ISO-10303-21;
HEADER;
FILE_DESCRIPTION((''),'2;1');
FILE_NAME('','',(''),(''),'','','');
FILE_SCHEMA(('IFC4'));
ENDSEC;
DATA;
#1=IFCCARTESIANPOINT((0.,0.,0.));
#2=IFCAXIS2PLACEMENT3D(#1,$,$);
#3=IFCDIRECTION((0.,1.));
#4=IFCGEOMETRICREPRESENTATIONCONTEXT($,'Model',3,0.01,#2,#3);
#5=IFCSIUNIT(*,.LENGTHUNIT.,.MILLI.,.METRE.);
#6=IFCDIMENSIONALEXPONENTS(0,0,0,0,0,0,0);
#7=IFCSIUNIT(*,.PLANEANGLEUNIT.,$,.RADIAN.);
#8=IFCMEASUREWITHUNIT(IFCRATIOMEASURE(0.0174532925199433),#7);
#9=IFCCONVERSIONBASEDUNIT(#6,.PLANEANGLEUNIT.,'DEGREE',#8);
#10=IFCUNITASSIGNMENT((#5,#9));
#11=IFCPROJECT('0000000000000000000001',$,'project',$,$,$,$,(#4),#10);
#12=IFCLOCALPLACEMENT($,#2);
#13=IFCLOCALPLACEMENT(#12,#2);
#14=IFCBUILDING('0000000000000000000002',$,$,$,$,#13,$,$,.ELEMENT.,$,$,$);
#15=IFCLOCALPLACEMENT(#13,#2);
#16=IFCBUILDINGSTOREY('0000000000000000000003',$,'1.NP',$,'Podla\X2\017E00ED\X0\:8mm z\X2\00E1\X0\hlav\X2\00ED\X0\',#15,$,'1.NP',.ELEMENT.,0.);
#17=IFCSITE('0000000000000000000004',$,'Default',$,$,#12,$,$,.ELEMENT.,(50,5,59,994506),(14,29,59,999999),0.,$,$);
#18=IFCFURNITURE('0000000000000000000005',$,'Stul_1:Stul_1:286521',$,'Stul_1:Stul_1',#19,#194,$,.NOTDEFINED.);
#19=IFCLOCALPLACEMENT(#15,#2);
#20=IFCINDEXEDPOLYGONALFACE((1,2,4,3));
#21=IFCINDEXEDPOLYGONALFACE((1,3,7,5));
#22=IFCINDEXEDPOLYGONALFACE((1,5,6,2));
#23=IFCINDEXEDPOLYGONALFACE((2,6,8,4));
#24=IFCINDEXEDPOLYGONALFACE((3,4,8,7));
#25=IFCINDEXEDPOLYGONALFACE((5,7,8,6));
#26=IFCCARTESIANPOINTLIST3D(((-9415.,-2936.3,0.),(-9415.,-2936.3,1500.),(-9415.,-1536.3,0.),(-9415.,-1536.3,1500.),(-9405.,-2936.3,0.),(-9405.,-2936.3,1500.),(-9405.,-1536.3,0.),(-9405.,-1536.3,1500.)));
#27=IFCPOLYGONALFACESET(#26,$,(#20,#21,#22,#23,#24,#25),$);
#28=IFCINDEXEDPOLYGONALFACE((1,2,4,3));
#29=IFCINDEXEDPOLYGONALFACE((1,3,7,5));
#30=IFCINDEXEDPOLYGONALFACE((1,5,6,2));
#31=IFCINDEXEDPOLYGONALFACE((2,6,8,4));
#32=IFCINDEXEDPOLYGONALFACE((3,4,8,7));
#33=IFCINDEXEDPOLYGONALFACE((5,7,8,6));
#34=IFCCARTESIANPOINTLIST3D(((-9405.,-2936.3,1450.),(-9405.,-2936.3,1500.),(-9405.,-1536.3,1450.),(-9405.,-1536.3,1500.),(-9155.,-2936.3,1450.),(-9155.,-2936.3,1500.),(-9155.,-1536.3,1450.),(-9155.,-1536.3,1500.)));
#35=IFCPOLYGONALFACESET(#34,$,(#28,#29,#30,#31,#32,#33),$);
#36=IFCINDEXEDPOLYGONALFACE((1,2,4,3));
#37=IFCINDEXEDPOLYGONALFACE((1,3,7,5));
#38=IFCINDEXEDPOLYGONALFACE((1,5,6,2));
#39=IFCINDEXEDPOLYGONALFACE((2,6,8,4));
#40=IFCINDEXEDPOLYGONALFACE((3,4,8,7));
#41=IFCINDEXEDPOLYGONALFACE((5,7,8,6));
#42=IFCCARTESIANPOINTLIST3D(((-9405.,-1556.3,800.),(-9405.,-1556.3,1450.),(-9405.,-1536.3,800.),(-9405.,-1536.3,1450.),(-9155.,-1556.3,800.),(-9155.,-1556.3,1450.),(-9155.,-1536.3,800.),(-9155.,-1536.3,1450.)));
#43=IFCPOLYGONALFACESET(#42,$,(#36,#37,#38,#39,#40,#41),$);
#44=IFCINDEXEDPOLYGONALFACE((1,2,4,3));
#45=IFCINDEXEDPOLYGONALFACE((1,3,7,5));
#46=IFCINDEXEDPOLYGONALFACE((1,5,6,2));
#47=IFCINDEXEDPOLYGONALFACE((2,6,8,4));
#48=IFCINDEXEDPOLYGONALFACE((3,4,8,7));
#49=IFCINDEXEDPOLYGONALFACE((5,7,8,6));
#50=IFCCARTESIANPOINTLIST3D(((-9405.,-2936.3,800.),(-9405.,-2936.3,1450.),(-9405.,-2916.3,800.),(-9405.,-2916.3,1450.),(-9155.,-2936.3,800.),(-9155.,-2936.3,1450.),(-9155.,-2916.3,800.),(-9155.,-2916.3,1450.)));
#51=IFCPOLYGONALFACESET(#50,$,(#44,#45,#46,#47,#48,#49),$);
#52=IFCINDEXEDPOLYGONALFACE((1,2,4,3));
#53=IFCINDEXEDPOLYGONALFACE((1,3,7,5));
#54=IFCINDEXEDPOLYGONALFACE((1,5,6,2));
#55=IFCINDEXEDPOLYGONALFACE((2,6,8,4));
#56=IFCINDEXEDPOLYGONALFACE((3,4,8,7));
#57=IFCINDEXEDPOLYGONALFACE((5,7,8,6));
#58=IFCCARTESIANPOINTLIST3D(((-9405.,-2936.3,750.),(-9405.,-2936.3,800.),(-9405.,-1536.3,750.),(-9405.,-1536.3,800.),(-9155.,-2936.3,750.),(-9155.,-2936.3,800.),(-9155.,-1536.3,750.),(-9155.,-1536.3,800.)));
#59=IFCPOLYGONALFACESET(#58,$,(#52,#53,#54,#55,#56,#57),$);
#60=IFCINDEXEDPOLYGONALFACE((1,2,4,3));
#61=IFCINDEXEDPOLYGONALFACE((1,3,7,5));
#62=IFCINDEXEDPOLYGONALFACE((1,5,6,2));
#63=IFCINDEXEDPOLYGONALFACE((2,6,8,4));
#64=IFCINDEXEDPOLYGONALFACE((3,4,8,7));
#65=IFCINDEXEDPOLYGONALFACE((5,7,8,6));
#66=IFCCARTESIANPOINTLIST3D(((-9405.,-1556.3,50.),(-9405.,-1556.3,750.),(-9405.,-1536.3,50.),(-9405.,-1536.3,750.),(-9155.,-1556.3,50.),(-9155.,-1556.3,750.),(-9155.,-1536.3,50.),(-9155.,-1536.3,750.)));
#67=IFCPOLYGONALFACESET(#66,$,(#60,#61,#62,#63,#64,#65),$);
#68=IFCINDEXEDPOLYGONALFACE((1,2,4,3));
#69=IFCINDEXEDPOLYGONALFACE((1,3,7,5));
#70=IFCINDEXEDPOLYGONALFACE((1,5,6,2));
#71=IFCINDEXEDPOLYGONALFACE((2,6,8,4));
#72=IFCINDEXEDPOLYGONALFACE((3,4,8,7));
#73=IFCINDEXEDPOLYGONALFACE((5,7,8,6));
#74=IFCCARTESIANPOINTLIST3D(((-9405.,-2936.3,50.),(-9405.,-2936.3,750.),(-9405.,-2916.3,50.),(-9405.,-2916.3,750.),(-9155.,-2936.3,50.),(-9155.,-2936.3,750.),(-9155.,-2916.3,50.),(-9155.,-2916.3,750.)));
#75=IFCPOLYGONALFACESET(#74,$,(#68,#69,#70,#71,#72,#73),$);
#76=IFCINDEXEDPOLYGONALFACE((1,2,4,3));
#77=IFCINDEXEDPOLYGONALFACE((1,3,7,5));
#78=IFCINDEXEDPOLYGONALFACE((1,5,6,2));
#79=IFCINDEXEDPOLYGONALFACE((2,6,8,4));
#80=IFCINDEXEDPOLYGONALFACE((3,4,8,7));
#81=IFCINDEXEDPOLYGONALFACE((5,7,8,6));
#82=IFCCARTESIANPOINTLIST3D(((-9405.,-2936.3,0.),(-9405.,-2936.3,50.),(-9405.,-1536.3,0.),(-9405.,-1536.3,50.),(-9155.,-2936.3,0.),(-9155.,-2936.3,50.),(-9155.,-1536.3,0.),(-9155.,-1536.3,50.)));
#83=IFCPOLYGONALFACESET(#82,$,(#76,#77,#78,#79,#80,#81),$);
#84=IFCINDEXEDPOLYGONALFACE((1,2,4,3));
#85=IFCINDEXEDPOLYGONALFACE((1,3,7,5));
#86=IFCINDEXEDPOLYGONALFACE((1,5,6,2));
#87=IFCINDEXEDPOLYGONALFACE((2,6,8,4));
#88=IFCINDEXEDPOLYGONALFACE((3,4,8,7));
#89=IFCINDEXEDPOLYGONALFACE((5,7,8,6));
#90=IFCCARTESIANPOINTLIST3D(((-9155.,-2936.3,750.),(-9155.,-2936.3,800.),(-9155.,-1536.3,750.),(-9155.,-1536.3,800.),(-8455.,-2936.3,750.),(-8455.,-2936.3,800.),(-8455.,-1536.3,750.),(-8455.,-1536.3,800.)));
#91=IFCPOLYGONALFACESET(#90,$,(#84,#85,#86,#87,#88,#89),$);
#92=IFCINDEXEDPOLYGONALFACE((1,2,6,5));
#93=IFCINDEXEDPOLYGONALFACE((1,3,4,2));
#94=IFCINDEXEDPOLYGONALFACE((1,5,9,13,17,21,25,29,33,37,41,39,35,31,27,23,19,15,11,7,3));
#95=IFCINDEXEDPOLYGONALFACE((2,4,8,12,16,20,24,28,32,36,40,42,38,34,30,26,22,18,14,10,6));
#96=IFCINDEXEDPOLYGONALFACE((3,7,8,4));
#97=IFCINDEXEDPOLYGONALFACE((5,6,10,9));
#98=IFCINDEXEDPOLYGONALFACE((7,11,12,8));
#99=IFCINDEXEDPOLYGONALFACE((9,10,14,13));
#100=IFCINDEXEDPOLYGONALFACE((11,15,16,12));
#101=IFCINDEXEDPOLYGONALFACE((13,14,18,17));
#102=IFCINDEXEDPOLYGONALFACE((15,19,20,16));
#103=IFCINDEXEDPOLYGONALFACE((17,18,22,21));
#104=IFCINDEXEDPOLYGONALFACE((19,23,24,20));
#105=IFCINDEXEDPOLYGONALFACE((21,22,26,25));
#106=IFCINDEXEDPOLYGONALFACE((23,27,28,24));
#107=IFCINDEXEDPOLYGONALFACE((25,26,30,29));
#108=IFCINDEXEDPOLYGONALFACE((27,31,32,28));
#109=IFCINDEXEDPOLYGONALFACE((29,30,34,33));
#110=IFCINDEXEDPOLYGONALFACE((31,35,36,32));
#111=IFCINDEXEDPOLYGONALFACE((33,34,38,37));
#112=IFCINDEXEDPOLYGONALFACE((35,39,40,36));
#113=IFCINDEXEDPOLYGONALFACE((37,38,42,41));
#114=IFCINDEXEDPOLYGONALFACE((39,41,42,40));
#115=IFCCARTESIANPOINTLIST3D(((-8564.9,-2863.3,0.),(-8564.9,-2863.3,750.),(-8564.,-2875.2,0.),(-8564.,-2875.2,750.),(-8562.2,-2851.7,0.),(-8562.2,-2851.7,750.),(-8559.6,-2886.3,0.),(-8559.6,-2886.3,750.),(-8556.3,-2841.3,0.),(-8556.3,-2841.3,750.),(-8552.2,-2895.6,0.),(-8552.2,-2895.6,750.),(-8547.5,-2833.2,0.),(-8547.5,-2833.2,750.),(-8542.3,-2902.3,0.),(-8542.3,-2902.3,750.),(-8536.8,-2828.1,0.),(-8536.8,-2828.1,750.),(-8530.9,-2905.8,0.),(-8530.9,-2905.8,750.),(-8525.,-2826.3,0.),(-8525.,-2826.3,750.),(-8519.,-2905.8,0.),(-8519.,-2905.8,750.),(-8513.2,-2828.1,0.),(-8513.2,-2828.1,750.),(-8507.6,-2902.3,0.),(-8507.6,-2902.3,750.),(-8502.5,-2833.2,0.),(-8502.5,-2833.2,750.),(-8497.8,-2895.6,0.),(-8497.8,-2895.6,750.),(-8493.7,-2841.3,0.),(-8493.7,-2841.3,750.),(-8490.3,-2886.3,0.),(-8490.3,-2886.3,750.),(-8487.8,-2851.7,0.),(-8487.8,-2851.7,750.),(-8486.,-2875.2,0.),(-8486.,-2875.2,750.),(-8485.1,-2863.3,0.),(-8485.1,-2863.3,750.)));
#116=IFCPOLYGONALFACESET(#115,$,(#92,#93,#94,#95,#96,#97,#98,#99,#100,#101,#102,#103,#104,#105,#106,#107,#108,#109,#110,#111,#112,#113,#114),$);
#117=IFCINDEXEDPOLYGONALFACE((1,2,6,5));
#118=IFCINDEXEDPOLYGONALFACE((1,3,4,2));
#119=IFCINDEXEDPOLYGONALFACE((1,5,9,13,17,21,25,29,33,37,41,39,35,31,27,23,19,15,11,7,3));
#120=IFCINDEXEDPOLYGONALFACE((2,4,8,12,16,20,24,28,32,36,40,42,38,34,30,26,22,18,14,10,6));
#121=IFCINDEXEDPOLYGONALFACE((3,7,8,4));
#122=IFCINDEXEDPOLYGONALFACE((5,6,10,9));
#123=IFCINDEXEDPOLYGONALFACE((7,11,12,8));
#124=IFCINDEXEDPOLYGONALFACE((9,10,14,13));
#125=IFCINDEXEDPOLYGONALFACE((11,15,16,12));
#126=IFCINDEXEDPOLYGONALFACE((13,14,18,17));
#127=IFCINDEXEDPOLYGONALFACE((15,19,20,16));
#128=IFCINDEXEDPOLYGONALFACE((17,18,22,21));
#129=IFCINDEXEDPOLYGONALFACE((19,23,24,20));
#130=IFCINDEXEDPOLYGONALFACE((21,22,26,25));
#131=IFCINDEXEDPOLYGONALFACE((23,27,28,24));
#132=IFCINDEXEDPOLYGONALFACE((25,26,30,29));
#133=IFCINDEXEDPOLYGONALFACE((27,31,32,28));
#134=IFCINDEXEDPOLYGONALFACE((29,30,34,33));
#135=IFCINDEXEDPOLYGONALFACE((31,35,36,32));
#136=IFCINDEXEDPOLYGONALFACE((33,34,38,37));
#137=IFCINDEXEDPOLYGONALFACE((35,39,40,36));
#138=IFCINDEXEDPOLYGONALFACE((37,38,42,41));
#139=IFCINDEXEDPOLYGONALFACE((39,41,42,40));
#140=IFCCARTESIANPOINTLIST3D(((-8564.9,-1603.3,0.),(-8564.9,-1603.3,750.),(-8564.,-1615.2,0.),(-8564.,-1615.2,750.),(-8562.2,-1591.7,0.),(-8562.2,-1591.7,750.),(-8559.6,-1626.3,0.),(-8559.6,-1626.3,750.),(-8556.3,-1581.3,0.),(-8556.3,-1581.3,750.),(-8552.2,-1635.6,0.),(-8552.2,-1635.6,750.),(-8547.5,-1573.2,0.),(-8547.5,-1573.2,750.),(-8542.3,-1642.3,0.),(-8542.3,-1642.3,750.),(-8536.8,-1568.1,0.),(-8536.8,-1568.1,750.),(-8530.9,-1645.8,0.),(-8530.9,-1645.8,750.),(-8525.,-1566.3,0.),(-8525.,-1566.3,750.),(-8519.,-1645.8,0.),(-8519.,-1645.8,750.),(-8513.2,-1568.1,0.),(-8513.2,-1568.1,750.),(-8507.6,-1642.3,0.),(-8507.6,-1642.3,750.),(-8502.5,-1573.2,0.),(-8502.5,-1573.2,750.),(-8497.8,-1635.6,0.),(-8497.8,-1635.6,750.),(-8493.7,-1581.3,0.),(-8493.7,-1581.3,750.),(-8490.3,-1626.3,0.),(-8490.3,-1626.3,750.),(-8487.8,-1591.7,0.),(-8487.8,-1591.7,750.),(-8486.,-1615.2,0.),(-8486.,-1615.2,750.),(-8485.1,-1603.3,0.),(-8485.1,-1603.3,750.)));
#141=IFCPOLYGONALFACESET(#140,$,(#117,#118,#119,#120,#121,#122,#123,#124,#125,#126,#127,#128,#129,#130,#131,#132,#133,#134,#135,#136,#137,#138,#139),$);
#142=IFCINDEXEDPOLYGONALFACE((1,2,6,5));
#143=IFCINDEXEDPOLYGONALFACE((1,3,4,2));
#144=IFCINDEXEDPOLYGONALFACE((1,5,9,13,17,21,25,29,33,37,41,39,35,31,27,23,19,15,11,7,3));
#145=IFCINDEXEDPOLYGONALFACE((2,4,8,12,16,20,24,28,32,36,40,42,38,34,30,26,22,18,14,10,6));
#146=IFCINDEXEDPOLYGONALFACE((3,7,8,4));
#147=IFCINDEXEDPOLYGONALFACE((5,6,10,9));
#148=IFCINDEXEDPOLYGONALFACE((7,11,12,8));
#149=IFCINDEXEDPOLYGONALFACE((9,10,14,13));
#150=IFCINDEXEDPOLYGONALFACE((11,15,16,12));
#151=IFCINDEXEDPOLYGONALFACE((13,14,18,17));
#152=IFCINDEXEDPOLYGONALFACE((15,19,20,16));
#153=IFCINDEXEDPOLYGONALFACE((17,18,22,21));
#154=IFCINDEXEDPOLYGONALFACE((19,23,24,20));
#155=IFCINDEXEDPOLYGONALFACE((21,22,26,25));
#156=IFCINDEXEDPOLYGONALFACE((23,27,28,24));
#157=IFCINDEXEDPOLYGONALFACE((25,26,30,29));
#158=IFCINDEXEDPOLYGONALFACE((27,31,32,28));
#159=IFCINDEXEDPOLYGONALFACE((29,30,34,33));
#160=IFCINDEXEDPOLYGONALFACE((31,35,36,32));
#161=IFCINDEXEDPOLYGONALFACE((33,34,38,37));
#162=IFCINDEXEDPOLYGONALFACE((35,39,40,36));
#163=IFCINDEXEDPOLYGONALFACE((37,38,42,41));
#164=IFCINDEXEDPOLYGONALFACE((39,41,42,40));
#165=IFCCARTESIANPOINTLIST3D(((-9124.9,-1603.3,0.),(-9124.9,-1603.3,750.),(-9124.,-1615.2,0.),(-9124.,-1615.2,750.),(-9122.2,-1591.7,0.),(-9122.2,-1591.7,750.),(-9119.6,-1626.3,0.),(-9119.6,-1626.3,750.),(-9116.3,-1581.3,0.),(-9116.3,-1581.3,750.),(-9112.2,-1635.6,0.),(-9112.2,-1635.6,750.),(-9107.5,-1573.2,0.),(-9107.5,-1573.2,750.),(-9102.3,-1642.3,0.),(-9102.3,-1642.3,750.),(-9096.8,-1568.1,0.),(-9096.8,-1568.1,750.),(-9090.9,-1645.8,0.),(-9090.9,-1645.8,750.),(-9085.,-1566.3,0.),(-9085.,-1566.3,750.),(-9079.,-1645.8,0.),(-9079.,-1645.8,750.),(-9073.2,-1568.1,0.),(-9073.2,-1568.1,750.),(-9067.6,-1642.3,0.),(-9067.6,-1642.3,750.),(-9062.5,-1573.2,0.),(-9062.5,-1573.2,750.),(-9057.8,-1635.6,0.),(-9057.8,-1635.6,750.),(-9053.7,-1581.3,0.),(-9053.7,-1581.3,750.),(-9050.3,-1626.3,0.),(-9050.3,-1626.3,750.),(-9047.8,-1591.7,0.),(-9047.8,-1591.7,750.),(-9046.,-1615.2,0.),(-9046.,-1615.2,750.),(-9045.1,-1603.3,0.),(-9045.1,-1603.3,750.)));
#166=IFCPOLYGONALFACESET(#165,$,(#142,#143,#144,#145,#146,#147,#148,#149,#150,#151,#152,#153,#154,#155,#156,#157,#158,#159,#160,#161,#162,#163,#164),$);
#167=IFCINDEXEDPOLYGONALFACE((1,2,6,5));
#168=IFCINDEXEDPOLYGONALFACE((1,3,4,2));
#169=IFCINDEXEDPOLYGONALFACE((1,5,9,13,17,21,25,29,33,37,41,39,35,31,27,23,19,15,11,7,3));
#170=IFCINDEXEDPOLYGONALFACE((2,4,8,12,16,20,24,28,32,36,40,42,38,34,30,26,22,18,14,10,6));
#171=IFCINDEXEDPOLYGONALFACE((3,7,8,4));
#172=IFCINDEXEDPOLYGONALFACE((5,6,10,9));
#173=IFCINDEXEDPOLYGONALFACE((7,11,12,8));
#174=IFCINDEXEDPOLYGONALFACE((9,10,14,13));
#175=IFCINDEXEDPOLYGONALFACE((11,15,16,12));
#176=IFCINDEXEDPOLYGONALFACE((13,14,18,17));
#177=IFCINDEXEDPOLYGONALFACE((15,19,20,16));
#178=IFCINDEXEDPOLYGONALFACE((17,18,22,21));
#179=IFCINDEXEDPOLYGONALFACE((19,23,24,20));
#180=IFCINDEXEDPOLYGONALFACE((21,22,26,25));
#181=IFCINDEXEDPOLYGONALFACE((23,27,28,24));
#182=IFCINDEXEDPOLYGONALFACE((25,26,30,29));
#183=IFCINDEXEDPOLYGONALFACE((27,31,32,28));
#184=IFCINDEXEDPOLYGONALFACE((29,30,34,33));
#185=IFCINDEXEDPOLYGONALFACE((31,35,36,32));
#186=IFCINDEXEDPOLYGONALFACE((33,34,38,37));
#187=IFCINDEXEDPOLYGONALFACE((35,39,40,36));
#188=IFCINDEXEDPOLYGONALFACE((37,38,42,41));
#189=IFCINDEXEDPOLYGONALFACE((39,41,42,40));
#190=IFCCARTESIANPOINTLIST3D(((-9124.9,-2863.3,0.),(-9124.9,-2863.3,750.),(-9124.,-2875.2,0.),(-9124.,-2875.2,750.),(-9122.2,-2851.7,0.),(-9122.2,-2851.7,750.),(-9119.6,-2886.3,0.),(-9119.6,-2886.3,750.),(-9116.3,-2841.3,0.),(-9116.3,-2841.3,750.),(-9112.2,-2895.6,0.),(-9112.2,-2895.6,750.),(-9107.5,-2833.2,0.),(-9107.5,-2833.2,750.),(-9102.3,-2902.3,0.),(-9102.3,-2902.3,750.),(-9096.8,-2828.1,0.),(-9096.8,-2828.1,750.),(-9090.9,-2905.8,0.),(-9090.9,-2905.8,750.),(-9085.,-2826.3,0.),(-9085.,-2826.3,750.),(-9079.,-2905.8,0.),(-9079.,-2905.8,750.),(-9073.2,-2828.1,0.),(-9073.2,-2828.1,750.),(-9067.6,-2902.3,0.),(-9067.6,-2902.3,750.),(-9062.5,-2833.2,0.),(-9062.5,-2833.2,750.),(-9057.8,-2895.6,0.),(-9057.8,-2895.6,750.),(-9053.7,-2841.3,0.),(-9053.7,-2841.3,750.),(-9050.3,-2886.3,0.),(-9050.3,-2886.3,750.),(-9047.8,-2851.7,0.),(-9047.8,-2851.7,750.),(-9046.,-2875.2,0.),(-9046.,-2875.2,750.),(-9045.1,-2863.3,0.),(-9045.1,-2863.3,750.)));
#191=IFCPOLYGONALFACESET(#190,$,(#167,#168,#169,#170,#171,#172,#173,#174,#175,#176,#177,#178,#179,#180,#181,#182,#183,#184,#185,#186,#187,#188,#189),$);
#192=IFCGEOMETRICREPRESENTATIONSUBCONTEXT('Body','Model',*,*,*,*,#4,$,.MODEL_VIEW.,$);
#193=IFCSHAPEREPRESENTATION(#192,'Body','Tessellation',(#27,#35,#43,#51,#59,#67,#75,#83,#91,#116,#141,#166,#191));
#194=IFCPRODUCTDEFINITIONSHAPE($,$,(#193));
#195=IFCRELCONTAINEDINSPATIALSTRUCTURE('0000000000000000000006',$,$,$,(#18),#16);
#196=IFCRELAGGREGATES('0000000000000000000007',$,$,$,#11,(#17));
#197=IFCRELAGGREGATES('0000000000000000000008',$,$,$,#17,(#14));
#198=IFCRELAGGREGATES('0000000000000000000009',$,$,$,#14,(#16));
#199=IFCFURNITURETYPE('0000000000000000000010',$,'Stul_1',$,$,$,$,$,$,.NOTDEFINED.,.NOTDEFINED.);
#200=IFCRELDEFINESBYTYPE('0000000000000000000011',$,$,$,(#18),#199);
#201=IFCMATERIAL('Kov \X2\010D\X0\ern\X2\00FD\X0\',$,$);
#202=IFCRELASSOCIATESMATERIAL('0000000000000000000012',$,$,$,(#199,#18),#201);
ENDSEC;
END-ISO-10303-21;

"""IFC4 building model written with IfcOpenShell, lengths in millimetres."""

from ifc_helpers import new_model, entity, si_unit, converted_unit, direction, frame, frame_2d, origin, origin_2d_with_axis, place, context, subcontext, project, spatial, rectangle, circle, extrude, source, transform, mapped, material, type_object, type_shapes, element, save


model = new_model("IFC4")

# Units and contexts
model_context = context("Model", 3, precision=0.01, world=origin(), true_north=direction((0.0, 1.0)))
body_context = subcontext(model_context, "Body", "Model", "MODEL_VIEW")
ifc_project = project(units=[si_unit("LENGTHUNIT", "METRE", prefix="MILLI"), converted_unit("PLANEANGLEUNIT", "DEGREE", entity("IfcRatioMeasure", 0.0174532925199433), si_unit("PLANEANGLEUNIT", "RADIAN"), dimensions=[0, 0, 0, 0, 0, 0, 0])], contexts=[model_context])

# Site, building, storey
site_placement = place(None, origin())
site = spatial("IfcSite", under=ifc_project, at=site_placement, Name="Default", CompositionType="ELEMENT", RefLatitude=(50, 5, 59, 994506), RefLongitude=(14, 29, 59, 999999), RefElevation=0.0)
building_placement = place(site_placement, origin())
building = spatial("IfcBuilding", under=site, at=building_placement, CompositionType="ELEMENT")
storey_placement = place(building_placement, origin())
storey = spatial("IfcBuildingStorey", under=building, at=storey_placement, Name="1.NP", ObjectType="Podlaží:8mm záhlaví", LongName="1.NP", CompositionType="ELEMENT", Elevation=0.0)

# Furniture
ifc_material_1 = material(Name="Kov černý")
furniture_type = type_object("IfcFurnitureType", Name="Stul_1", AssemblyPlace="NOTDEFINED", PredefinedType="NOTDEFINED", material=ifc_material_1)
shared_shape_1 = source(origin(), body_context, "Body", "SweptSolid", [
    extrude(rectangle(XDim=1400.0, YDim=10.0, at=origin_2d_with_axis()), frame((0.0, 605.0, 0.0), z_axis=(0.0, 0.0, 1.0), x_axis=(-1.0, 0.0, 0.0)), (0.0, 0.0, 1.0), 1500.0),
    extrude(rectangle(XDim=1400.0, YDim=250.0, at=frame_2d((0.0, 0.0), x_axis=(1.0, 0.0))), frame((0.0, 475.0, 1450.0), z_axis=(0.0, 0.0, 1.0), x_axis=(-1.0, 0.0, 0.0)), (0.0, 0.0, 1.0), 50.0),
    extrude(rectangle(XDim=20.0, YDim=250.0, at=origin_2d_with_axis()), frame((690.0, 475.0, 800.0), z_axis=(0.0, 0.0, 1.0), x_axis=(-1.0, 0.0, 0.0)), (0.0, 0.0, 1.0), 650.0),
    extrude(rectangle(XDim=20.0, YDim=250.0, at=frame_2d((0.0, 0.0), x_axis=(1.0, 0.0))), frame((-690.0, 475.0, 800.0), z_axis=(0.0, 0.0, 1.0), x_axis=(-1.0, 0.0, 0.0)), (0.0, 0.0, 1.0), 650.0),
    extrude(rectangle(XDim=1400.0, YDim=250.0, at=origin_2d_with_axis()), frame((0.0, 475.0, 750.0), z_axis=(0.0, 0.0, 1.0), x_axis=(-1.0, 0.0, 0.0)), (0.0, 0.0, 1.0), 50.0),
    extrude(rectangle(XDim=20.0, YDim=250.0, at=origin_2d_with_axis()), frame((690.0, 475.0, 50.0), z_axis=(0.0, 0.0, 1.0), x_axis=(-1.0, 0.0, 0.0)), (0.0, 0.0, 1.0), 700.0),
    extrude(rectangle(XDim=20.0, YDim=250.0, at=frame_2d((0.0, 0.0), x_axis=(1.0, 0.0))), frame((-690.0, 475.0, 50.0), z_axis=(0.0, 0.0, 1.0), x_axis=(-1.0, 0.0, 0.0)), (0.0, 0.0, 1.0), 700.0),
    extrude(rectangle(XDim=1400.0, YDim=250.0, at=origin_2d_with_axis()), frame((0.0, 475.0, 0.0), z_axis=(0.0, 0.0, 1.0), x_axis=(-1.0, 0.0, 0.0)), (0.0, 0.0, 1.0), 50.0),
    extrude(rectangle(XDim=1400.0, YDim=700.0, at=origin_2d_with_axis()), frame((0.0, 0.0, 750.0), z_axis=(0.0, 0.0, 1.0), x_axis=(-1.0, 0.0, 0.0)), (0.0, 0.0, 1.0), 50.0),
    extrude(circle(Radius=40.0, at=frame_2d((0.0, 0.0), x_axis=(1.0, 0.0))), frame((-630.0, -280.0, 0.0)), (0.0, 0.0, 1.0), 750.0),
    extrude(circle(Radius=40.0, at=frame_2d((0.0, 0.0), x_axis=(1.0, 0.0))), frame((630.0, -280.0, 0.0)), (0.0, 0.0, 1.0), 750.0),
    extrude(circle(Radius=40.0, at=frame_2d((0.0, 0.0), x_axis=(1.0, 0.0))), frame((630.0, 280.0, 0.0)), (0.0, 0.0, 1.0), 750.0),
    extrude(circle(Radius=40.0, at=frame_2d((0.0, 0.0), x_axis=(1.0, 0.0))), frame((-630.0, 280.0, 0.0)), (0.0, 0.0, 1.0), 750.0),
])
type_shapes(furniture_type, [shared_shape_1])
for number, where, z_axis, x_axis, name in (
    (1, (-8805.0, -2236.3, 0.0), (0.0, 0.0, 1.0), (0.0, 1.0, 0.0), "Stul_1:Stul_1:286521"),
):
    element("IfcFurniture", number, at=place(storey_placement, frame(where, z_axis=z_axis, x_axis=x_axis)), inside=storey, type_object=furniture_type, material=ifc_material_1, Name=name, ObjectType="Stul_1:Stul_1", PredefinedType="NOTDEFINED", context=body_context, shape_type="MappedRepresentation", body=[
        mapped(shared_shape_1, transform((0.0, 0.0, 0.0), scale=1.0)),
    ])

save(model, "model.ifc")
